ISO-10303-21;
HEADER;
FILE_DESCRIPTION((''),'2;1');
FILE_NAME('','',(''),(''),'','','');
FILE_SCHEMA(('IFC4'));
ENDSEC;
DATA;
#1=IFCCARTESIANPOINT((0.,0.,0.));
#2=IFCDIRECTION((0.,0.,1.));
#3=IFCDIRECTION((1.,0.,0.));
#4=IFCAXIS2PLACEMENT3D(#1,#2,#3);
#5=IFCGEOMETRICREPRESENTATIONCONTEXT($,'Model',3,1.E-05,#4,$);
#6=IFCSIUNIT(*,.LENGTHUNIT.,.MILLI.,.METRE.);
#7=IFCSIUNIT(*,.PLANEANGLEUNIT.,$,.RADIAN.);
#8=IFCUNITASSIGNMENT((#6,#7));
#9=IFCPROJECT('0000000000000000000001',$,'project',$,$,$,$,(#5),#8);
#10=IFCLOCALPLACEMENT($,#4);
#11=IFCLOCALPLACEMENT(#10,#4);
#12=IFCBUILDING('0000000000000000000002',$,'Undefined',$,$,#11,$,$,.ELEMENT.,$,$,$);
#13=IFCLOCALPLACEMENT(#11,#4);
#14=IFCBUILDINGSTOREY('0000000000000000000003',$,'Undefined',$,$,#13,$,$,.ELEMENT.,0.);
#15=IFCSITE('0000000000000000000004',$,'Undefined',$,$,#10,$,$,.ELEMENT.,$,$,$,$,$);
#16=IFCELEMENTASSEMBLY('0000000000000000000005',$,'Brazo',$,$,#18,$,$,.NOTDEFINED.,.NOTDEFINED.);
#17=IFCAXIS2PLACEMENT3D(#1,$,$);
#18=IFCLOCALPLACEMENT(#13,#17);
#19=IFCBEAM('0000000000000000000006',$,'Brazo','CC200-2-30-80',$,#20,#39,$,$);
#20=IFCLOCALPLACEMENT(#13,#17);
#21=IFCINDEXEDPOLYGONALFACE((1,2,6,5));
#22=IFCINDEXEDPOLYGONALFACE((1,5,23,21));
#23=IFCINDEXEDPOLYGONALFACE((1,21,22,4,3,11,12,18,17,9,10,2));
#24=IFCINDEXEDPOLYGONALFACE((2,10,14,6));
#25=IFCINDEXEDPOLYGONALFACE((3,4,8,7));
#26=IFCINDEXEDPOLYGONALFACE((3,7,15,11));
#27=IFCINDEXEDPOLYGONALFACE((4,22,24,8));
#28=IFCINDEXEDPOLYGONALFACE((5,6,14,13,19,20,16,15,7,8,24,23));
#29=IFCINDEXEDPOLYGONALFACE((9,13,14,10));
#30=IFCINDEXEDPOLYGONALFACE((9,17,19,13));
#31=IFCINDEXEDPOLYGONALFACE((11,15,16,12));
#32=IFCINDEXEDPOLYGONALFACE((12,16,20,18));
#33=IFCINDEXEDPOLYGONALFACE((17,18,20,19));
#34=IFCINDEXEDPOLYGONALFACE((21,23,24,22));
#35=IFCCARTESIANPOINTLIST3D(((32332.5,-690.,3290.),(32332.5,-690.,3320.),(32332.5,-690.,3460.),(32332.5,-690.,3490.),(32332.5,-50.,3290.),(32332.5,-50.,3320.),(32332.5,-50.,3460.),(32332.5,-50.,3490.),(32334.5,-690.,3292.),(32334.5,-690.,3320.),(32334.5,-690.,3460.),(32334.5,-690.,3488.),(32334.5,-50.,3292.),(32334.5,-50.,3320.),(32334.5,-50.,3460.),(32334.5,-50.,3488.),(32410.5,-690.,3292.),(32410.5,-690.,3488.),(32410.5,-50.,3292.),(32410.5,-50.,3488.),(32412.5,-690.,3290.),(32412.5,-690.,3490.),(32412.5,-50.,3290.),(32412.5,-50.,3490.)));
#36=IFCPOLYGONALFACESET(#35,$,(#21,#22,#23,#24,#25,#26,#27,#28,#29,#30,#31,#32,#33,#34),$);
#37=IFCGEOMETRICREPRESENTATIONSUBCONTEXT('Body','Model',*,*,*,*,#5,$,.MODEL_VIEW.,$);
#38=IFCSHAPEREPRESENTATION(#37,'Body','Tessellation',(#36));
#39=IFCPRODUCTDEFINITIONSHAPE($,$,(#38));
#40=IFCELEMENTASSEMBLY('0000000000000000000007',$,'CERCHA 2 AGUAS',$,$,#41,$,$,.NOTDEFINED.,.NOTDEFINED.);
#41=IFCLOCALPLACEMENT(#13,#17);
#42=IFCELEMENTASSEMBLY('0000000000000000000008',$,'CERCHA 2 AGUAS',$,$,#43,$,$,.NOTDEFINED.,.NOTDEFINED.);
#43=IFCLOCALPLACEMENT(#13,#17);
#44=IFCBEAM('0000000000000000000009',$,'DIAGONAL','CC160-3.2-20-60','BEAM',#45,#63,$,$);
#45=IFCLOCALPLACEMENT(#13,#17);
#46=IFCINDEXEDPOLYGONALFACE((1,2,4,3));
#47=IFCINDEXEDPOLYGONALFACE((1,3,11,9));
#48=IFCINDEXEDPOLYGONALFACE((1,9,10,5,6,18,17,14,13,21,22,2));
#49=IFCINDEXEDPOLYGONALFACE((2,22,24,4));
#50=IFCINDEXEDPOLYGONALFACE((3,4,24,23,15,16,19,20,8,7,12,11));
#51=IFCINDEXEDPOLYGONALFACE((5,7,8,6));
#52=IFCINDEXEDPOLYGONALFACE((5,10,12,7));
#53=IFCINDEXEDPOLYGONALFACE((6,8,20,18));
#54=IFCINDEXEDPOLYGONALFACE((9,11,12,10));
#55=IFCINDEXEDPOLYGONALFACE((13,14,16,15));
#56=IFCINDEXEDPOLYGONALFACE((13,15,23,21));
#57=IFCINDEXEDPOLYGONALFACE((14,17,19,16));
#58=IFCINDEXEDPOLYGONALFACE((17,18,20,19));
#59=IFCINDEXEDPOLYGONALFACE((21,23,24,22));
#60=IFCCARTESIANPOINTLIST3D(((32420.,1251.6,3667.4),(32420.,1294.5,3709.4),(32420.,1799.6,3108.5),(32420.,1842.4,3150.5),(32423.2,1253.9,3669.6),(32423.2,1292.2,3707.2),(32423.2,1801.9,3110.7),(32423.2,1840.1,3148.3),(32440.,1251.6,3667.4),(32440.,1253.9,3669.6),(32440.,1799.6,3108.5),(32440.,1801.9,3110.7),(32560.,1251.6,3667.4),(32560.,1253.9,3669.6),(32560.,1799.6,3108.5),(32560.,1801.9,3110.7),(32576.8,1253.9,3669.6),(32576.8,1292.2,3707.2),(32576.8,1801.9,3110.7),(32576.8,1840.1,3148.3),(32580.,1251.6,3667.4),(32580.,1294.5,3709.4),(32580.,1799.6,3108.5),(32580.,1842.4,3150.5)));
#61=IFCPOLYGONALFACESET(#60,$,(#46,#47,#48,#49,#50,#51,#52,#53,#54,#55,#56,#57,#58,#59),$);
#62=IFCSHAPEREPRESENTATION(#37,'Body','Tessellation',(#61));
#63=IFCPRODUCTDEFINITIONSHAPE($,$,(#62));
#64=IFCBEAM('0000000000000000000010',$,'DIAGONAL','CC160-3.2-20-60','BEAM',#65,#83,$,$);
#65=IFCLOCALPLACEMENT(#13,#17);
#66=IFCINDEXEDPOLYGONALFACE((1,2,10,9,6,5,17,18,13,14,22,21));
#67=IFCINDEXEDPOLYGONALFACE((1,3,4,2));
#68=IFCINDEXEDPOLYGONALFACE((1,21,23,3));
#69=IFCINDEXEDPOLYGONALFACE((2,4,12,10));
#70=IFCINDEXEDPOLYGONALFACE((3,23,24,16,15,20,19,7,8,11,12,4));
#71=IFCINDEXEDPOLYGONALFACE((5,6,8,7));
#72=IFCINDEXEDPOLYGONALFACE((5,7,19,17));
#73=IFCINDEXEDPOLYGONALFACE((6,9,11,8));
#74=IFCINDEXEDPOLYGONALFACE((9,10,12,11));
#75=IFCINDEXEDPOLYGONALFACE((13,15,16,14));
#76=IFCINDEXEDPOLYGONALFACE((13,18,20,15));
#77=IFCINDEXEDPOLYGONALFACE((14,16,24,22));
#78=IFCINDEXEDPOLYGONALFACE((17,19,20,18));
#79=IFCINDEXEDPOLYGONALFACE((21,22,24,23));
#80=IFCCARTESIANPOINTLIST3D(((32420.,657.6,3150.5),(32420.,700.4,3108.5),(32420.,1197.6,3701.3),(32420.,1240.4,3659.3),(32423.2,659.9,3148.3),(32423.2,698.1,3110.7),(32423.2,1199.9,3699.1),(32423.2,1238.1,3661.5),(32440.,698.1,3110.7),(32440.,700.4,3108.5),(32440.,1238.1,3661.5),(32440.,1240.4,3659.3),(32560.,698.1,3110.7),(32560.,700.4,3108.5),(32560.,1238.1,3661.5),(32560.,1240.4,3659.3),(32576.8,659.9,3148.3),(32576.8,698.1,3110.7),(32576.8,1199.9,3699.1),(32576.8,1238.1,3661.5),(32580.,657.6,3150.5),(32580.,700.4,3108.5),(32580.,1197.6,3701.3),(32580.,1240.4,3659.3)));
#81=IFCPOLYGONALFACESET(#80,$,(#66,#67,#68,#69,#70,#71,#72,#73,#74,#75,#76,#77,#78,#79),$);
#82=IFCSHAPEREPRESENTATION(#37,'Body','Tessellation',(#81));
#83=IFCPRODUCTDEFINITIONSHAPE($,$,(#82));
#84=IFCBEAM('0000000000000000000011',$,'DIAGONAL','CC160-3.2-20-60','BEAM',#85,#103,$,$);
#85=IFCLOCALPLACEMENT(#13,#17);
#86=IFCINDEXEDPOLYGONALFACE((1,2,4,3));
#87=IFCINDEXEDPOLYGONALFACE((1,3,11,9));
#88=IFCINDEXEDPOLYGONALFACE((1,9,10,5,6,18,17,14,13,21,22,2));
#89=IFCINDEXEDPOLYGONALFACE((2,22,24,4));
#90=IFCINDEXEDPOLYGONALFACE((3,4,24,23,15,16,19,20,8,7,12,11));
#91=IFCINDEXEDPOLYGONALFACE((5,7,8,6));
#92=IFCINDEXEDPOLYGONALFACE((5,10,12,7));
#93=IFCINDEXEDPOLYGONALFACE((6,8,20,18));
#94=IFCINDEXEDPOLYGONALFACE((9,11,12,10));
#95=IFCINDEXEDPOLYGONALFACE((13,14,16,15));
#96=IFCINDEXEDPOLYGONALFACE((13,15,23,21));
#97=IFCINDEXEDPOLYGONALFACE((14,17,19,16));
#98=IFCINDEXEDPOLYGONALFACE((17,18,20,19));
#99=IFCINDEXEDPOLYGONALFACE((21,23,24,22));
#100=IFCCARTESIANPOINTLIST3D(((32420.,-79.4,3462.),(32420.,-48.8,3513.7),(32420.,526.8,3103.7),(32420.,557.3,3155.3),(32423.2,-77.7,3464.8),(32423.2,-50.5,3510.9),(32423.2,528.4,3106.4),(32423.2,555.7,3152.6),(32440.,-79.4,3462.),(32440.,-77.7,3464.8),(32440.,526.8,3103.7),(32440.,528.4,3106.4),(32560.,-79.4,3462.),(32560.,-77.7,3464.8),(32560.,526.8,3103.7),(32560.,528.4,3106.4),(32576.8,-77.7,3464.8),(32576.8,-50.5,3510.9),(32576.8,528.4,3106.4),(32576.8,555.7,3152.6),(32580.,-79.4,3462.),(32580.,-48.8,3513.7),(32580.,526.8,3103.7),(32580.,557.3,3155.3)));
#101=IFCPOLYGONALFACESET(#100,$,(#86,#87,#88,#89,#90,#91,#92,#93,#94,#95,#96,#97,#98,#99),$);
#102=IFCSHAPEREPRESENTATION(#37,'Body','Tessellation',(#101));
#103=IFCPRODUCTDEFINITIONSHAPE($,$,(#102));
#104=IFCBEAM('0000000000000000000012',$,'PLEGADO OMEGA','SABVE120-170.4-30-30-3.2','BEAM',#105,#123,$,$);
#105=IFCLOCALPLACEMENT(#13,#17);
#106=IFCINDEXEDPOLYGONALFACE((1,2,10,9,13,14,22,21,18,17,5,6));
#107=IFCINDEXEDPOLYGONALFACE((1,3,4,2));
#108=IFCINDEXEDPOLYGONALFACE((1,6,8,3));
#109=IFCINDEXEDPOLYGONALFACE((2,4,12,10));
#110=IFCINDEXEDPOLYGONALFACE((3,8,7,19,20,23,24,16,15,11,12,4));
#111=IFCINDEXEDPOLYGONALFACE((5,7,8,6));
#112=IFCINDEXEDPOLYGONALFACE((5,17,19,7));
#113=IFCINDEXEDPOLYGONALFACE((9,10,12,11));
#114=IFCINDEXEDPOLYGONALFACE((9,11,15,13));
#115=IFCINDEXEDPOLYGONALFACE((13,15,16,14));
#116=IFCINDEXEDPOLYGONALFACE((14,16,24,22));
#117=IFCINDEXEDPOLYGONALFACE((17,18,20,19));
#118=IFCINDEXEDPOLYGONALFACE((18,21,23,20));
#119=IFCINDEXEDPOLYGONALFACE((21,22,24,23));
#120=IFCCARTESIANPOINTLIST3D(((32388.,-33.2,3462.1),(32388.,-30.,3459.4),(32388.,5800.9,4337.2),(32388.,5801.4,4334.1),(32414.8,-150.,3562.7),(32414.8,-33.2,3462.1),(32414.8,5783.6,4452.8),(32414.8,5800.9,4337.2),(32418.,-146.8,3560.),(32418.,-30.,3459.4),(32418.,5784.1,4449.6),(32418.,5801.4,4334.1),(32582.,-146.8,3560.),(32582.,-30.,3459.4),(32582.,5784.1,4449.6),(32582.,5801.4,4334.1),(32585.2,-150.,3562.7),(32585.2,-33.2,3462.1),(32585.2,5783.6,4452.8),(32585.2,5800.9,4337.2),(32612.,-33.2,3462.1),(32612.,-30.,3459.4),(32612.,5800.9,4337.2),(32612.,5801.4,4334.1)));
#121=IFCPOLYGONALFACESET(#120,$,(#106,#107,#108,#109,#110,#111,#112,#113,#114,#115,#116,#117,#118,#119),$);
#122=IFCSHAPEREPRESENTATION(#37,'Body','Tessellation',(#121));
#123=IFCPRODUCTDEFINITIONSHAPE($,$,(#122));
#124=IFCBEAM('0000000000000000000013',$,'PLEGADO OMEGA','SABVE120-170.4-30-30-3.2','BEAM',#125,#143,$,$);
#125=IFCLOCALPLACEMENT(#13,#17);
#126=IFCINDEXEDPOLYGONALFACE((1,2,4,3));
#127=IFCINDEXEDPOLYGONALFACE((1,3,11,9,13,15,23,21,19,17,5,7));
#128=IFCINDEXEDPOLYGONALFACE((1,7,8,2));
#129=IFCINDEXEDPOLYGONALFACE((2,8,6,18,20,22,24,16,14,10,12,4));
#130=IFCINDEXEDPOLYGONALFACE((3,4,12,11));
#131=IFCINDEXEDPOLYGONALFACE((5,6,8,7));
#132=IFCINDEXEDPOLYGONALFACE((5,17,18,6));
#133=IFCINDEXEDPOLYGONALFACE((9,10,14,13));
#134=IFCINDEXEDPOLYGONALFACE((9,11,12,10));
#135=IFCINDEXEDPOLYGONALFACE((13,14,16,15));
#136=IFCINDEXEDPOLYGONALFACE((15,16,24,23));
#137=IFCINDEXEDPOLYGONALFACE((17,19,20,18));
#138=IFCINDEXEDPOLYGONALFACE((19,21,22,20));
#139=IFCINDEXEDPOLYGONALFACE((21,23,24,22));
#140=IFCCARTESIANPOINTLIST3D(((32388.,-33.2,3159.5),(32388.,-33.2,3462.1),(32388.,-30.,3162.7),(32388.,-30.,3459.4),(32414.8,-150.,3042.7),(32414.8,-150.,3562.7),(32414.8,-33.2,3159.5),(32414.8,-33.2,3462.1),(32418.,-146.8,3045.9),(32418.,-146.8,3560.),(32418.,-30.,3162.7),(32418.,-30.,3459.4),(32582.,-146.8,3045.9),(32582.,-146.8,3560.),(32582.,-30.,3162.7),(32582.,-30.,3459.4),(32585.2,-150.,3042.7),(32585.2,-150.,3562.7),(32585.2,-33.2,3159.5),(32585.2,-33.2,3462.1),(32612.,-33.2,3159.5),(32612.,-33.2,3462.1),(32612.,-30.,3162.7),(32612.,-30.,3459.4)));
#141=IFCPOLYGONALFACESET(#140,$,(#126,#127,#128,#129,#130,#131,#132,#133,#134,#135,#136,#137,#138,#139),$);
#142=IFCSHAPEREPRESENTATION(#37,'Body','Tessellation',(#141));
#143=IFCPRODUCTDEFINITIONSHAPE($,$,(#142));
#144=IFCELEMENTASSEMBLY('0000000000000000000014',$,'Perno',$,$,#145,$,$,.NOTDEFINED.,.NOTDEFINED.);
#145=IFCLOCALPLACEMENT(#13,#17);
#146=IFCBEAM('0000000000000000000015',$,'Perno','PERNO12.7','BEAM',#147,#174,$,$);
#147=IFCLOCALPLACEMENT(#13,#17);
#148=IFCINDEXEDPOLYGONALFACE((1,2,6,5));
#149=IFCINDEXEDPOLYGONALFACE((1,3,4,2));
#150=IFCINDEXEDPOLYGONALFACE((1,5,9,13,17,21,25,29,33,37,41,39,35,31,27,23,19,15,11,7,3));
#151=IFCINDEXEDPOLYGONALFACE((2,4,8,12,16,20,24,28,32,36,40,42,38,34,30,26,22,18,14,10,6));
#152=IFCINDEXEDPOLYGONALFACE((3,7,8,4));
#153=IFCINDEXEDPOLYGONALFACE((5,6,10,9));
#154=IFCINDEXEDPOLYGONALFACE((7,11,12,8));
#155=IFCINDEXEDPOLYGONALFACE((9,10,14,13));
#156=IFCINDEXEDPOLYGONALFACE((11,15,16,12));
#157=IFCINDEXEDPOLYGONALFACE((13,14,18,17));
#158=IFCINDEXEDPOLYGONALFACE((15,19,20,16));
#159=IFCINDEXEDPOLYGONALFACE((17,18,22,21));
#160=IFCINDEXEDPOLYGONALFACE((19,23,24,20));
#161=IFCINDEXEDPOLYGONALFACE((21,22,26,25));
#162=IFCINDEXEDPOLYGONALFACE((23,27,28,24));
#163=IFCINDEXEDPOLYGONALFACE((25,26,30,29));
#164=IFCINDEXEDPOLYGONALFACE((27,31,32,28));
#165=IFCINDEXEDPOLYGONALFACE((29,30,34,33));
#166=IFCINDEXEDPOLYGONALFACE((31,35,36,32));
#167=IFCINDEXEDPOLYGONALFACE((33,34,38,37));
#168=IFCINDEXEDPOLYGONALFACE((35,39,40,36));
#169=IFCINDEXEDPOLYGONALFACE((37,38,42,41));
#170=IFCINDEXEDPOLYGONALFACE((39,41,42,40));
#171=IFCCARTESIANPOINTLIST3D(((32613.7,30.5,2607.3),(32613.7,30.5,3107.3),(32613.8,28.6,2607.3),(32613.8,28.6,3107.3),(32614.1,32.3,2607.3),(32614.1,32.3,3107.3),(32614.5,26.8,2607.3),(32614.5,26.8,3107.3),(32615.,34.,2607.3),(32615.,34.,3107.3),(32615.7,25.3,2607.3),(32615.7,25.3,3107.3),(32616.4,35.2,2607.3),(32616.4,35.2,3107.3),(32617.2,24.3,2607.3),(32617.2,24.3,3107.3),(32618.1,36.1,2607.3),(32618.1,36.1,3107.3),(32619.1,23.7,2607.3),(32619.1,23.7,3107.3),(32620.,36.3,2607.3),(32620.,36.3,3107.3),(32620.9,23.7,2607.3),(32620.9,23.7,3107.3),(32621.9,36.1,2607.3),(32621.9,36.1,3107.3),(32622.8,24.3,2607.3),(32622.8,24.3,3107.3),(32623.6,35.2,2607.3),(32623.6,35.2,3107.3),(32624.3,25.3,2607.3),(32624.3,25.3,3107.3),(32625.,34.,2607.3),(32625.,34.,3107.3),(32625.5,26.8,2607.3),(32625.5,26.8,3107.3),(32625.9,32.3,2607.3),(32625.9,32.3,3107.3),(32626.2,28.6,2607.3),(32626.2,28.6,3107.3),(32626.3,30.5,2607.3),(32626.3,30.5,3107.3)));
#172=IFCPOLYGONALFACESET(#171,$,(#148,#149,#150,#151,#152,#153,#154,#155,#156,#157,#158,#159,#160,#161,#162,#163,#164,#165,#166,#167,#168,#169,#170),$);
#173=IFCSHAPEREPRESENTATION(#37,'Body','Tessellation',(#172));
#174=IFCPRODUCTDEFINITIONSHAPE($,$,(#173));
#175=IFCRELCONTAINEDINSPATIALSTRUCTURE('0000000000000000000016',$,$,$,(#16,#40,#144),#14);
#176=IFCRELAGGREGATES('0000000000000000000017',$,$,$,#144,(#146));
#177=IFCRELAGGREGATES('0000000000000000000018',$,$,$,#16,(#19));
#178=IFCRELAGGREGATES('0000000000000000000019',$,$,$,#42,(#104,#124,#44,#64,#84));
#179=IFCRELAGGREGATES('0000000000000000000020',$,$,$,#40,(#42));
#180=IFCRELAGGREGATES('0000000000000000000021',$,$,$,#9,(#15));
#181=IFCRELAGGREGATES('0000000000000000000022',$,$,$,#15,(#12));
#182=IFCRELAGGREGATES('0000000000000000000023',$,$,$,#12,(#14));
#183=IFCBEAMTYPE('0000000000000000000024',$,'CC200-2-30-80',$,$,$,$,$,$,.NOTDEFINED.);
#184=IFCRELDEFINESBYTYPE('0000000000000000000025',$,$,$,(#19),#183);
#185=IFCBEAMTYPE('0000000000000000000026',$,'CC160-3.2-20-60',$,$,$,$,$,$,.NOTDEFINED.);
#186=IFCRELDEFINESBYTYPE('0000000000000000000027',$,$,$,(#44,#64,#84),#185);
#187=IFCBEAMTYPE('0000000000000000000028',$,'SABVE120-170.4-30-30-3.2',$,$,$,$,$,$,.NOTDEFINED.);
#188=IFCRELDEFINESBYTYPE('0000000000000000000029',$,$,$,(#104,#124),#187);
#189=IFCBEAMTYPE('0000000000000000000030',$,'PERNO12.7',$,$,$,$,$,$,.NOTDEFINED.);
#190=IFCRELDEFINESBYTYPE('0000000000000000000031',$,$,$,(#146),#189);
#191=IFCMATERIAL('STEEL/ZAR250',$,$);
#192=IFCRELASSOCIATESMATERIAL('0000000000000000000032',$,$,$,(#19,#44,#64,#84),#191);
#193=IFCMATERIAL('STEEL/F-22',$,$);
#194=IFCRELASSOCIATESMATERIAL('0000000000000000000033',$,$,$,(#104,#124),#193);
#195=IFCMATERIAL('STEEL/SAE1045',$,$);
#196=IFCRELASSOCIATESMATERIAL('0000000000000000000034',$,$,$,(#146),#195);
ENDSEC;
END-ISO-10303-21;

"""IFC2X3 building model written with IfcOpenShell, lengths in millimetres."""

from ifc_helpers import new_model, si_unit, frame, origin_with_axes, origin_2d_with_axis, place, context, subcontext, project, spatial, polyline, circle, c_section, outline, extrude, clip, halfspace, material, type_object, element, aggregate, save


model = new_model("IFC2X3")

# Units and contexts
model_context = context("Model", 3, precision=1e-05, world=origin_with_axes())
body_context = subcontext(model_context, "Body", "Model", "MODEL_VIEW")
ifc_project = project(units=[si_unit("LENGTHUNIT", "METRE", prefix="MILLI"), si_unit("PLANEANGLEUNIT", "RADIAN")], contexts=[model_context])

# Site, building, storey
site_placement = place(None, origin_with_axes())
site = spatial("IfcSite", under=ifc_project, at=site_placement, Name="Undefined", CompositionType="ELEMENT")
building_placement = place(site_placement, origin_with_axes())
building = spatial("IfcBuilding", under=site, at=building_placement, Name="Undefined", CompositionType="ELEMENT")
storey_placement = place(building_placement, origin_with_axes())
storey = spatial("IfcBuildingStorey", under=building, at=storey_placement, Name="Undefined", CompositionType="ELEMENT", Elevation=0.0)

# Element assembly, beam
assembly_1_placement = place(storey_placement, origin_with_axes())
assembly_1 = element("IfcElementAssembly", 1, at=assembly_1_placement, inside=storey, Name="Brazo", AssemblyPlace="NOTDEFINED", PredefinedType="NOTDEFINED")
ifc_material_1 = material(Name="STEEL/ZAR250")
beam_type_1 = type_object("IfcBeamType", Name="CC200-2-30-80", PredefinedType="NOTDEFINED")
beam_1_placement = place(assembly_1_placement, frame((32372.5, -50.0, 3390.0), z_axis=(0.0, -0.000005, 1.0), x_axis=(-0.000004, -1.0, -0.000005)))
beam_1 = element("IfcBeam", 2, at=beam_1_placement, type_object=beam_type_1, material=ifc_material_1, Name="Brazo", Description="CC200-2-30-80", context=body_context, shape_type="SweptSolid", body=[
    extrude(c_section(Depth=200.0, Width=80.0, WallThickness=2.0, Girth=30.0, at=origin_2d_with_axis()), frame((640.0, 0.0, 0.0), z_axis=(-1.0, 0.0, 0.0), x_axis=(0.0, -1.0, 0.0)), (0.0, 0.0, 1.0), 640.0),
])

# Element assemblies, beams
assembly_2_placement = place(storey_placement, origin_with_axes())
assembly_2 = element("IfcElementAssembly", 3, at=assembly_2_placement, inside=storey, Name="CERCHA 2 AGUAS", AssemblyPlace="NOTDEFINED", PredefinedType="NOTDEFINED")
assembly_3_placement = place(assembly_2_placement, origin_with_axes())
assembly_3 = element("IfcElementAssembly", 4, at=assembly_3_placement, Name="CERCHA 2 AGUAS", AssemblyPlace="NOTDEFINED", PredefinedType="NOTDEFINED")
beam_type_2 = type_object("IfcBeamType", Name="CC160-3.2-20-60", PredefinedType="NOTDEFINED")
beam_2_placement = place(assembly_3_placement, frame((32500.0, 1273.1, 3688.4), z_axis=(1.0, 0.0, 0.0), x_axis=(0.0, 0.700071, -0.714073)))
beam_2 = element("IfcBeam", 5, at=beam_2_placement, type_object=beam_type_2, material=ifc_material_1, Name="DIAGONAL", Description="CC160-3.2-20-60", ObjectType="BEAM", context=body_context, shape_type="SweptSolid", body=[
    extrude(c_section(Depth=160.0, Width=60.0, WallThickness=3.2, Girth=20.0, at=origin_2d_with_axis()), frame((782.7, 0.0, 0.0), z_axis=(-1.0, 0.0, 0.0), x_axis=(0.0, -1.0, 0.0)), (0.0, 0.0, 1.0), 782.7),
])
beam_3_placement = place(assembly_3_placement, frame((32500.0, 679.0, 3129.5), z_axis=(1.0, 0.0, 0.0), x_axis=(0.0, 0.700071, 0.714073)))
beam_3 = element("IfcBeam", 6, at=beam_3_placement, type_object=beam_type_2, material=ifc_material_1, Name="DIAGONAL", Description="CC160-3.2-20-60", ObjectType="BEAM", context=body_context, shape_type="SweptSolid", body=[
    extrude(c_section(Depth=160.0, Width=60.0, WallThickness=3.2, Girth=20.0, at=origin_2d_with_axis()), frame((771.3, 0.0, 0.0), z_axis=(-1.0, 0.0, 0.0), x_axis=(0.0, -1.0, 0.0)), (0.0, 0.0, 1.0), 771.3),
])
beam_4_placement = place(assembly_3_placement, frame((32500.0, -64.1, 3487.8), z_axis=(1.0, 0.0, 0.0), x_axis=(0.0, 0.860828, -0.508895)))
beam_4 = element("IfcBeam", 7, at=beam_4_placement, type_object=beam_type_2, material=ifc_material_1, Name="DIAGONAL", Description="CC160-3.2-20-60", ObjectType="BEAM", context=body_context, shape_type="SweptSolid", body=[
    extrude(c_section(Depth=160.0, Width=60.0, WallThickness=3.2, Girth=20.0, at=origin_2d_with_axis()), frame((704.1, 0.0, 0.0), z_axis=(-1.0, 0.0, 0.0), x_axis=(0.0, -1.0, 0.0)), (0.0, 0.0, 1.0), 704.1),
])
ifc_material_2 = material(Name="STEEL/F-22")
beam_type_3 = type_object("IfcBeamType", Name="SABVE120-170.4-30-30-3.2", PredefinedType="NOTDEFINED")
beam_5_placement = place(assembly_3_placement, frame((32500.0, -141.1, 3503.4), z_axis=(0.0, 0.14834, -0.988936), x_axis=(0.0, 0.988936, 0.14834)))
beam_5 = element("IfcBeam", 8, at=beam_5_placement, type_object=beam_type_3, material=ifc_material_2, Name="PLEGADO OMEGA", Description="SABVE120-170.4-30-30-3.2", ObjectType="BEAM", context=body_context, shape_type="Clipping", body=[
    clip(extrude(outline(polyline([(82.0, 60.0), (112.0, 60.0), (112.0, 56.8), (85.2, 56.8), (85.2, -60.0), (-85.2, -60.0), (-85.2, 56.8), (-112.0, 56.8), (-112.0, 60.0), (-82.0, 60.0), (-82.0, -56.8), (82.0, -56.8), (82.0, 60.0)])), frame((6000.0, 0.0, 0.0), z_axis=(-1.0, 0.0, 0.0), x_axis=(0.0, -1.0, 0.0)), (0.0, 0.0, 1.0), 6033.8), halfspace(frame((0.0, 0.0, -60.0), z_axis=(-0.757741, 0.0, 0.652555), x_axis=(0.0, 1.0, 0.0)), False)),
])
beam_6_placement = place(assembly_3_placement, frame((32500.0, -90.0, 3042.7), z_axis=(0.0, 1.0, -0.000004), x_axis=(0.0, 0.000004, 1.0)))
beam_6 = element("IfcBeam", 9, at=beam_6_placement, type_object=beam_type_3, material=ifc_material_2, Name="PLEGADO OMEGA", Description="SABVE120-170.4-30-30-3.2", ObjectType="BEAM", context=body_context, shape_type="Clipping", body=[
    clip(clip(extrude(outline(polyline([(82.0, 60.0), (112.0, 60.0), (112.0, 56.8), (85.2, 56.8), (85.2, -60.0), (-85.2, -60.0), (-85.2, 56.8), (-112.0, 56.8), (-112.0, 60.0), (-82.0, 60.0), (-82.0, -56.8), (82.0, -56.8), (82.0, 60.0)])), frame((581.1, 0.0, 0.0), z_axis=(-1.0, 0.0, 0.0), x_axis=(0.0, -1.0, 0.0)), (0.0, 0.0, 1.0), 633.9), halfspace(frame((520.0, 0.0, -60.0), z_axis=(-0.757741, 0.0, -0.652555), x_axis=(0.0, 1.0, 0.0)), True)), halfspace(frame((120.0, 0.0, 60.0), z_axis=(0.707106, 0.0, -0.707108), x_axis=(0.0, 1.0, 0.0)), True)),
])

# Element assembly, beam
assembly_4_placement = place(storey_placement, origin_with_axes())
assembly_4 = element("IfcElementAssembly", 10, at=assembly_4_placement, inside=storey, Name="Perno", AssemblyPlace="NOTDEFINED", PredefinedType="NOTDEFINED")
ifc_material_3 = material(Name="STEEL/SAE1045")
beam_type_4 = type_object("IfcBeamType", Name="PERNO12.7", PredefinedType="NOTDEFINED")
beam_7_placement = place(assembly_4_placement, frame((32620.0, 30.0, 3107.3), z_axis=(-1.0, 0.0, 0.0), x_axis=(0.0, 0.0, -1.0)))
beam_7 = element("IfcBeam", 11, at=beam_7_placement, type_object=beam_type_4, material=ifc_material_3, Name="Perno", Description="PERNO12.7", ObjectType="BEAM", context=body_context, shape_type="SweptSolid", body=[
    extrude(circle(Radius=6.3, at=origin_2d_with_axis()), frame((500.0, 0.0, 0.0), z_axis=(-1.0, 0.0, 0.0), x_axis=(0.0, -1.0, 0.0)), (0.0, 0.0, 1.0), 500.0),
])
aggregate(assembly_4, [beam_7])

aggregate(assembly_1, [beam_1])

aggregate(assembly_3, [beam_5, beam_6, beam_2, beam_3, beam_4])
aggregate(assembly_2, [assembly_3])

save(model, "model.ifc")
